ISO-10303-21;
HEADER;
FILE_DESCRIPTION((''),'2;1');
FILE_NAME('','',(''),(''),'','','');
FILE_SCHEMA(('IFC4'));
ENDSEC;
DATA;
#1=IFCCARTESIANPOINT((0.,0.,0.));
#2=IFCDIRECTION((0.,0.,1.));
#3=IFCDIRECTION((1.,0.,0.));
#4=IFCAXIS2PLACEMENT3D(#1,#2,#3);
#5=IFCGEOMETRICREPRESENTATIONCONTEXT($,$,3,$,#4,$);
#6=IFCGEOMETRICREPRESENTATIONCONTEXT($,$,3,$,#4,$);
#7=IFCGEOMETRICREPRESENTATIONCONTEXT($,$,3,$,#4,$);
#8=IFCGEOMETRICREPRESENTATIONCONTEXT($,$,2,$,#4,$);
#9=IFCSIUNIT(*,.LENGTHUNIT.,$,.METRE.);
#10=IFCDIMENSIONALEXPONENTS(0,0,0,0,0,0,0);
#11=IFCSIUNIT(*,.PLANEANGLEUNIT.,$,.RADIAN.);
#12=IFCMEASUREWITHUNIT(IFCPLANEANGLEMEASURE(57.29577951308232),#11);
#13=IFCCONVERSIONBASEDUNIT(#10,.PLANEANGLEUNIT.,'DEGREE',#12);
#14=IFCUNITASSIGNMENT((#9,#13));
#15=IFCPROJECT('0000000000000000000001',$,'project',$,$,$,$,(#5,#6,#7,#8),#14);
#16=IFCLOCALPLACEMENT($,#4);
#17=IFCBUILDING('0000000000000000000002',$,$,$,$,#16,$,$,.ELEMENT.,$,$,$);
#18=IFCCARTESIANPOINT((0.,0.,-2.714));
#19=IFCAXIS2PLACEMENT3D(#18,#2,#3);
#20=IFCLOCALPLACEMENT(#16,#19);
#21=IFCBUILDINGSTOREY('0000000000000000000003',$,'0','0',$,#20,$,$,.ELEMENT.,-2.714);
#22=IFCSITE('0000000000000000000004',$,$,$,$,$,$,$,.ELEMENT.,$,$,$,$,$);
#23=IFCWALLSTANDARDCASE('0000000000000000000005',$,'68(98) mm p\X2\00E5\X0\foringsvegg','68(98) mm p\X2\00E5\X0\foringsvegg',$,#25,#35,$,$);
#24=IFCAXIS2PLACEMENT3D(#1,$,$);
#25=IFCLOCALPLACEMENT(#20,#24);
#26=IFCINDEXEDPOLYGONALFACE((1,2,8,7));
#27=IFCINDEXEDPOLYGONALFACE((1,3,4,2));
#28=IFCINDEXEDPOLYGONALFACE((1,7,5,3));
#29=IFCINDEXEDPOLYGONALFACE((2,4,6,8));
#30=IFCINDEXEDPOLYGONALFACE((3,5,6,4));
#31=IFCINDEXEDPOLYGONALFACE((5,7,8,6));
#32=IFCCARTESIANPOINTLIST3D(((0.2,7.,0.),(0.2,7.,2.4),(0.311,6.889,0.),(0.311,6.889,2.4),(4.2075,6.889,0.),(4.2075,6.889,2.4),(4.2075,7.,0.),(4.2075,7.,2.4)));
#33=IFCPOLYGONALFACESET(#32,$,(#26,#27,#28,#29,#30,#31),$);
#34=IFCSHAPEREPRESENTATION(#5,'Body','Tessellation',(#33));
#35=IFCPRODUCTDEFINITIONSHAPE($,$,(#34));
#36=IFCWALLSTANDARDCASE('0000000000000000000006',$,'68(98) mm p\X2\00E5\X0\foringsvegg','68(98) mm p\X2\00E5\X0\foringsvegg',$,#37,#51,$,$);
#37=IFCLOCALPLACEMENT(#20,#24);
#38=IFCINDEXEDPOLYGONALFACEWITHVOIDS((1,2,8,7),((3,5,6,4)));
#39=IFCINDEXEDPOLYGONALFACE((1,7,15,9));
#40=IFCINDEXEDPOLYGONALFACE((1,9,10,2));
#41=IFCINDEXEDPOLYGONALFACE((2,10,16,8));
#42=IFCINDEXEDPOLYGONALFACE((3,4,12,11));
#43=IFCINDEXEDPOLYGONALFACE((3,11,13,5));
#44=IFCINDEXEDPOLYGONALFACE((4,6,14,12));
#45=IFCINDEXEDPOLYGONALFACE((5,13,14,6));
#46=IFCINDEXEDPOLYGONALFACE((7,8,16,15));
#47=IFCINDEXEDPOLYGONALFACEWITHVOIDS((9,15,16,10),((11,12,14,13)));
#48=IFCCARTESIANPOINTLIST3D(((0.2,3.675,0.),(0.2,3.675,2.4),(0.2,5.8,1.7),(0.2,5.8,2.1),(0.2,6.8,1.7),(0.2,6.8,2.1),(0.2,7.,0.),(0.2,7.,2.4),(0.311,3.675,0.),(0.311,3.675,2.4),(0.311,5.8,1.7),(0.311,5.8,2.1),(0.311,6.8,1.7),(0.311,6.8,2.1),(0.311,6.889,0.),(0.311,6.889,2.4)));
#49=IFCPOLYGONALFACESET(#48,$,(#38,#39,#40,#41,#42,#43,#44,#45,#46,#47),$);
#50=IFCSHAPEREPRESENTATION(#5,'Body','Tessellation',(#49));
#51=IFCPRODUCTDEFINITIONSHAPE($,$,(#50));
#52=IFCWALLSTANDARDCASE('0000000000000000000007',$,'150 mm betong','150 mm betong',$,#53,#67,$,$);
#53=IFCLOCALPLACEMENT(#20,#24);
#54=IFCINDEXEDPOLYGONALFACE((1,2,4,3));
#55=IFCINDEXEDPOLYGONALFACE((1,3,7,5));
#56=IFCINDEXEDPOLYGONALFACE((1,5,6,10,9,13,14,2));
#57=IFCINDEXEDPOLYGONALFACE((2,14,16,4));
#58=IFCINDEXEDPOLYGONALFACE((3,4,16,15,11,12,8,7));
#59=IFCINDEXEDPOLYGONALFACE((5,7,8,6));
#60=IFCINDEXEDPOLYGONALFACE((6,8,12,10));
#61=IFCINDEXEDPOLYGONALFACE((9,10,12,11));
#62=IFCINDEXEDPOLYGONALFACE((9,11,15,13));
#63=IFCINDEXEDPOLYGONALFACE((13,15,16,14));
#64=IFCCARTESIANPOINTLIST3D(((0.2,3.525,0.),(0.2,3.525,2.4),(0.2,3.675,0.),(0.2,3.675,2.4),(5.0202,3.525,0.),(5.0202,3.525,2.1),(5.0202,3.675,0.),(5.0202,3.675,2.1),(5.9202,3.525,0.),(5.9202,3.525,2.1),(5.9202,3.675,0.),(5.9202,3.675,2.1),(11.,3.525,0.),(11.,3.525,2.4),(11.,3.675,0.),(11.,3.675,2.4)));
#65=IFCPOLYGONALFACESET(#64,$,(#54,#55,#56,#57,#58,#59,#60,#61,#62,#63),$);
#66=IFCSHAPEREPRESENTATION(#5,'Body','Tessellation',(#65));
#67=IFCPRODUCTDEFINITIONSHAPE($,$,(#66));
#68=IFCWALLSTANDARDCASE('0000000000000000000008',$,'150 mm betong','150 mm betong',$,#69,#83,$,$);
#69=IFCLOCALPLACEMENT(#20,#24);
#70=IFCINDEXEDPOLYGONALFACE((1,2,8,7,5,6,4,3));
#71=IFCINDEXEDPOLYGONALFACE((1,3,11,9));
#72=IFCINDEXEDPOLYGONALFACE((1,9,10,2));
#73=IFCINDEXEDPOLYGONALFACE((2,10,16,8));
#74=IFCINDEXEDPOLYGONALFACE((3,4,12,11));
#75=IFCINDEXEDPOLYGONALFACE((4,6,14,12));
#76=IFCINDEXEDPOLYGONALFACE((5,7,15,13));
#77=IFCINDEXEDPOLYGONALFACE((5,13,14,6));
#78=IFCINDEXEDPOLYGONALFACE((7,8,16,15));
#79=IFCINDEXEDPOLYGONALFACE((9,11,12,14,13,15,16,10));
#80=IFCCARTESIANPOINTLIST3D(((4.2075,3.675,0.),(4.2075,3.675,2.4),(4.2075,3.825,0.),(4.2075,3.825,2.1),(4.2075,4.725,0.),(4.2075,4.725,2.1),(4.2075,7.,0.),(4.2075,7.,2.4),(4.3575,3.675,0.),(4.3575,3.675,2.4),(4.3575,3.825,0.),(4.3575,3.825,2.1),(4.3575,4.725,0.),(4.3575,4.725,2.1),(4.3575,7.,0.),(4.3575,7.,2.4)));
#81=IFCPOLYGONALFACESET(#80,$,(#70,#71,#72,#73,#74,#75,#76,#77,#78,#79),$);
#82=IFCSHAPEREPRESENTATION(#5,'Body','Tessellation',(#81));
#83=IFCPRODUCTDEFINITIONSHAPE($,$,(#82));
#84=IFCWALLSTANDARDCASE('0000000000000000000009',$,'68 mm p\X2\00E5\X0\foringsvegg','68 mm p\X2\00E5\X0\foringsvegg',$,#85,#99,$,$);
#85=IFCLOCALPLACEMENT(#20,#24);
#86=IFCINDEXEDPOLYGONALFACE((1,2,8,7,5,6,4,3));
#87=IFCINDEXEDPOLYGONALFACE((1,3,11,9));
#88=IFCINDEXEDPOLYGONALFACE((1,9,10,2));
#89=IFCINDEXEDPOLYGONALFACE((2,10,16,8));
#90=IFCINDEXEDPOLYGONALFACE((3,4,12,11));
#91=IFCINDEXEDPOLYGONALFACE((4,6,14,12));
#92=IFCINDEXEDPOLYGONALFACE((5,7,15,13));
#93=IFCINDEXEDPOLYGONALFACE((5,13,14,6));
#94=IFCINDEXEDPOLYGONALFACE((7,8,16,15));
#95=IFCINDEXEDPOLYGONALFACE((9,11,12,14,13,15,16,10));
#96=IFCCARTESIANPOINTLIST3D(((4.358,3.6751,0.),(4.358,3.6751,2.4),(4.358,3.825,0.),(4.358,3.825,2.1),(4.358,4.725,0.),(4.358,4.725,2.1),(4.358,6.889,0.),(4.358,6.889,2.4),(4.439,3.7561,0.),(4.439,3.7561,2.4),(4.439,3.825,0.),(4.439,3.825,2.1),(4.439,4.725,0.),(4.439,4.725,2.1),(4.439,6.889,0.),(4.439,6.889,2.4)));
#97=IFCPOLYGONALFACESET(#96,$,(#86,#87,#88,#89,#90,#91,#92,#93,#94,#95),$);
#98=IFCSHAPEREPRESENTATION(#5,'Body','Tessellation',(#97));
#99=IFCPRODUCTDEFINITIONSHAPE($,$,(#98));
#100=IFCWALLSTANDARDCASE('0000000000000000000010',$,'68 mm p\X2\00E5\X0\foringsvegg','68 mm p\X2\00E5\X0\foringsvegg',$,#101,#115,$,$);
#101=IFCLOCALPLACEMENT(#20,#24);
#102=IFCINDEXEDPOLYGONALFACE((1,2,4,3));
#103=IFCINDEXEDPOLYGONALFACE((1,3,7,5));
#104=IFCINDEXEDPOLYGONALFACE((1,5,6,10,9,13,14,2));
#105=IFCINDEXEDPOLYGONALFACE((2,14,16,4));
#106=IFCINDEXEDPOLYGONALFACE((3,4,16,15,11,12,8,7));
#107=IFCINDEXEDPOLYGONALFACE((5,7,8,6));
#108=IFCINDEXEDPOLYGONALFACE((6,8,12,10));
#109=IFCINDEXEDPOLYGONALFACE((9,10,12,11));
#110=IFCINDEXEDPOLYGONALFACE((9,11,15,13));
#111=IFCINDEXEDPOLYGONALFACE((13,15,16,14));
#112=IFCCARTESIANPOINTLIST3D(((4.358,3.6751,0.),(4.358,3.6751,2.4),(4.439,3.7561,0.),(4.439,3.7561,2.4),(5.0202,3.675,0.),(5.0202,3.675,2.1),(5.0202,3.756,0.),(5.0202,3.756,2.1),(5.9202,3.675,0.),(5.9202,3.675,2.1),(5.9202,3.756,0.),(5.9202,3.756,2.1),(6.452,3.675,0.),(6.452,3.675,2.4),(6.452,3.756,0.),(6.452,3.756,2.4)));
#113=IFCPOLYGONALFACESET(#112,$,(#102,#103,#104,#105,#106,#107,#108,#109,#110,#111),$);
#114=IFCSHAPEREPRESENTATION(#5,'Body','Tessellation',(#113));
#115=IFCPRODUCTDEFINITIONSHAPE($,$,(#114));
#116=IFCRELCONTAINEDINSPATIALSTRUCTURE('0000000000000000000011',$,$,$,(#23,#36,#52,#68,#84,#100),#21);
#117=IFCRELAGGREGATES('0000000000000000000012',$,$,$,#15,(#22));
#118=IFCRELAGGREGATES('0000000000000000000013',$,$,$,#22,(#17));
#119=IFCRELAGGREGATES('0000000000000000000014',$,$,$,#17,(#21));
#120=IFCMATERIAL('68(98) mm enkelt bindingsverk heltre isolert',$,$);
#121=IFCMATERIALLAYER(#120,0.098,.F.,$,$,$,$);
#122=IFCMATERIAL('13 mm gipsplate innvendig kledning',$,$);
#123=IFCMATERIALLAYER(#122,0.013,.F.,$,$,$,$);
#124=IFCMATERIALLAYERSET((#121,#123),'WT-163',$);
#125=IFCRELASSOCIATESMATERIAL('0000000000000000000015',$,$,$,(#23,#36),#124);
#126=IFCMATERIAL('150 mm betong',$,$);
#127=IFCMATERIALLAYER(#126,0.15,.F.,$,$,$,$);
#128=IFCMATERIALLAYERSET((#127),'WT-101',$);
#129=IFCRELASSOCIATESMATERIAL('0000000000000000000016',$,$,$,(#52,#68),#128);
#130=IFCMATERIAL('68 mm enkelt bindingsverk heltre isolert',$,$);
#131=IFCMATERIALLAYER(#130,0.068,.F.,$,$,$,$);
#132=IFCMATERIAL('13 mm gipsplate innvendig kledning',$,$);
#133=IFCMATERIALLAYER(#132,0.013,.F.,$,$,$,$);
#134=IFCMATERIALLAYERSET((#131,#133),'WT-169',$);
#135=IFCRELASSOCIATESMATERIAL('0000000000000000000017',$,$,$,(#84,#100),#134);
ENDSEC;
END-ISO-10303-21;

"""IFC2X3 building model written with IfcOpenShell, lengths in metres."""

from ifc_helpers import new_model, entity, si_unit, converted_unit, frame, origin_with_axes, place, context, project, spatial, polyline, outline, extrude, material, layer, layer_set, layer_usage, element, save


model = new_model("IFC2X3")

# Units and contexts
context_of_model_1 = context(None, 3, world=origin_with_axes())
context_of_model_2 = context(None, 3, world=origin_with_axes())
context_of_model_3 = context(None, 3, world=origin_with_axes())
context_of_model_4 = context(None, 2, world=origin_with_axes())
ifc_project = project(units=[si_unit("LENGTHUNIT", "METRE"), converted_unit("PLANEANGLEUNIT", "DEGREE", entity("IfcPlaneAngleMeasure", 57.29577951308232), si_unit("PLANEANGLEUNIT", "RADIAN"), dimensions=[0, 0, 0, 0, 0, 0, 0])], contexts=[context_of_model_1, context_of_model_2, context_of_model_3, context_of_model_4])

# Site, building, storey
site = spatial("IfcSite", under=ifc_project, CompositionType="ELEMENT")
building_placement = place(None, origin_with_axes())
building = spatial("IfcBuilding", under=site, at=building_placement, CompositionType="ELEMENT")
storey_placement = place(building_placement, frame((0.0, 0.0, -2.714), z_axis=(0.0, 0.0, 1.0), x_axis=(1.0, 0.0, 0.0)))
storey = spatial("IfcBuildingStorey", under=building, at=storey_placement, Name="0", Description="0", CompositionType="ELEMENT", Elevation=-2.714)

# Shared definitions
ifc_material_1 = material(Name="68(98) mm enkelt bindingsverk heltre isolert")
ifc_layer_1 = layer(ifc_material_1, 0.098, ventilated=False)
ifc_material_2 = material(Name="13 mm gipsplate innvendig kledning")
ifc_layer_2 = layer(ifc_material_2, 0.013, ventilated=False)
ifc_layer_set_1 = layer_set([ifc_layer_1, ifc_layer_2], Name="WT-163")
ifc_layer_usage_1 = layer_usage(ifc_layer_set_1, "AXIS2", "POSITIVE", 0.0)

# Wall
wall_1_placement = place(storey_placement, frame((4.2075, 7.0, 0.0), z_axis=(0.0, 0.0, 1.0), x_axis=(-1.0, 0.0, 0.0)))
element("IfcWallStandardCase", 1, at=wall_1_placement, inside=storey, material=ifc_layer_usage_1, Name="68(98) mm påforingsvegg", Description="68(98) mm påforingsvegg", context=context_of_model_1, shape_type="SweptSolid", body=[
    extrude(outline(polyline([(0.0, 0.0), (4.0075, 0.0), (3.8965, 0.111), (0.0, 0.111), (0.0, 0.0)])), frame((0.0, 0.0, 0.0), z_axis=(0.0, 0.0, 1.0), x_axis=(1.0, 0.0, 0.0)), (0.0, 0.0, 1.0), 2.4),
])

# Walls, openings
wall_2_placement = place(storey_placement, frame((0.2, 7.0, 0.0), z_axis=(0.0, 0.0, 1.0), x_axis=(0.0, -1.0, 0.0)))
wall_2 = element("IfcWallStandardCase", 2, at=wall_2_placement, inside=storey, material=ifc_layer_usage_1, Name="68(98) mm påforingsvegg", Description="68(98) mm påforingsvegg", context=context_of_model_1, shape_type="SweptSolid", body=[
    extrude(outline(polyline([(0.0, 0.0), (3.325, 0.0), (3.325, 0.111), (0.111, 0.111), (0.0, 0.0)])), frame((0.0, 0.0, 0.0), z_axis=(0.0, 0.0, 1.0), x_axis=(1.0, 0.0, 0.0)), (0.0, 0.0, 1.0), 2.4),
])
opening_1_placement = place(wall_2_placement, frame((0.2, 0.0, 1.7), z_axis=(0.0, 0.0, 1.0), x_axis=(1.0, 0.0, 0.0)))
element("IfcOpeningElement", 3, at=opening_1_placement, inside=storey, cuts=wall_2, context=context_of_model_1, shape_type="SweptSolid", body=[
    extrude(outline(polyline([(0.0, 0.0), (0.4, 0.0), (0.4, 1.0), (0.0, 1.0), (0.0, 0.0)])), frame((0.0, 0.0, 0.0), z_axis=(0.0, 1.0, 0.0), x_axis=(0.0, 0.0, 1.0)), (0.0, 0.0, 1.0), 0.111),
])
ifc_material_3 = material(Name="150 mm betong")
ifc_layer_3 = layer(ifc_material_3, 0.15, ventilated=False)
ifc_layer_set_2 = layer_set([ifc_layer_3], Name="WT-101")
ifc_layer_usage_2 = layer_usage(ifc_layer_set_2, "AXIS2", "POSITIVE", 0.0)
wall_3_placement = place(storey_placement, frame((0.2, 3.525, 0.0), z_axis=(0.0, 0.0, 1.0), x_axis=(1.0, 0.0, 0.0)))
wall_3 = element("IfcWallStandardCase", 4, at=wall_3_placement, inside=storey, material=ifc_layer_usage_2, Name="150 mm betong", Description="150 mm betong", context=context_of_model_1, shape_type="SweptSolid", body=[
    extrude(outline(polyline([(0.0, 0.0), (10.8, 0.0), (10.8, 0.15), (0.0, 0.15), (0.0, 0.0)])), origin_with_axes(), (0.0, 0.0, 1.0), 2.4),
])
opening_2_placement = place(wall_3_placement, frame((4.8202, 0.0, 0.0), z_axis=(0.0, 0.0, 1.0), x_axis=(1.0, 0.0, 0.0)))
element("IfcOpeningElement", 5, at=opening_2_placement, inside=storey, cuts=wall_3, context=context_of_model_1, shape_type="SweptSolid", body=[
    extrude(outline(polyline([(0.0, 0.0), (2.1, 0.0), (2.1, 0.9), (0.0, 0.9), (0.0, 0.0)])), frame((0.0, 0.0, 0.0), z_axis=(0.0, 1.0, 0.0), x_axis=(0.0, 0.0, 1.0)), (0.0, 0.0, 1.0), 0.15),
])
wall_4_placement = place(storey_placement, frame((4.2075, 7.0, 0.0), z_axis=(0.0, 0.0, 1.0), x_axis=(0.0, -1.0, 0.0)))
wall_4 = element("IfcWallStandardCase", 6, at=wall_4_placement, inside=storey, material=ifc_layer_usage_2, Name="150 mm betong", Description="150 mm betong", context=context_of_model_1, shape_type="SweptSolid", body=[
    extrude(outline(polyline([(0.0, 0.0), (3.325, 0.0), (3.325, 0.15), (0.0, 0.15), (0.0, 0.0)])), frame((0.0, 0.0, 0.0), z_axis=(0.0, 0.0, 1.0), x_axis=(1.0, 0.0, 0.0)), (0.0, 0.0, 1.0), 2.4),
])
opening_3_placement = place(wall_4_placement, frame((2.275, 0.0, 0.0), z_axis=(0.0, 0.0, 1.0), x_axis=(1.0, 0.0, 0.0)))
element("IfcOpeningElement", 7, at=opening_3_placement, inside=storey, cuts=wall_4, context=context_of_model_1, shape_type="SweptSolid", body=[
    extrude(outline(polyline([(0.0, 0.0), (2.1, 0.0), (2.1, 0.9), (0.0, 0.9), (0.0, 0.0)])), frame((0.0, 0.0, 0.0), z_axis=(0.0, 1.0, 0.0), x_axis=(0.0, 0.0, 1.0)), (0.0, 0.0, 1.0), 0.15),
])
ifc_material_4 = material(Name="68 mm enkelt bindingsverk heltre isolert")
ifc_layer_4 = layer(ifc_material_4, 0.068, ventilated=False)
ifc_material_5 = material(Name="13 mm gipsplate innvendig kledning")
ifc_layer_5 = layer(ifc_material_5, 0.013, ventilated=False)
ifc_layer_set_3 = layer_set([ifc_layer_4, ifc_layer_5], Name="WT-169")
ifc_layer_usage_3 = layer_usage(ifc_layer_set_3, "AXIS2", "POSITIVE", 0.0)
wall_5_placement = place(storey_placement, frame((4.358, 6.889, 0.0), z_axis=(0.0, 0.0, 1.0), x_axis=(0.0, -1.0, 0.0)))
wall_5 = element("IfcWallStandardCase", 8, at=wall_5_placement, inside=storey, material=ifc_layer_usage_3, Name="68 mm påforingsvegg", Description="68 mm påforingsvegg", context=context_of_model_1, shape_type="SweptSolid", body=[
    extrude(outline(polyline([(0.0, 0.0), (3.2139, 0.0), (3.1329, 0.081), (0.0, 0.081), (0.0, 0.0)])), frame((0.0, 0.0, 0.0), z_axis=(0.0, 0.0, 1.0), x_axis=(1.0, 0.0, 0.0)), (0.0, 0.0, 1.0), 2.4),
])
opening_4_placement = place(wall_5_placement, frame((2.164, 0.0, 0.0), z_axis=(0.0, 0.0, 1.0), x_axis=(1.0, 0.0, 0.0)))
element("IfcOpeningElement", 9, at=opening_4_placement, inside=storey, cuts=wall_5, context=context_of_model_1, shape_type="SweptSolid", body=[
    extrude(outline(polyline([(0.0, 0.0), (2.1, 0.0), (2.1, 0.9), (0.0, 0.9), (0.0, 0.0)])), frame((0.0, 0.0, 0.0), z_axis=(0.0, 1.0, 0.0), x_axis=(0.0, 0.0, 1.0)), (0.0, 0.0, 1.0), 0.081),
])
wall_6_placement = place(storey_placement, frame((4.358, 3.6751, 0.0), z_axis=(0.0, 0.0, 1.0), x_axis=(1.0, 0.0, 0.0)))
wall_6 = element("IfcWallStandardCase", 10, at=wall_6_placement, inside=storey, material=ifc_layer_usage_3, Name="68 mm påforingsvegg", Description="68 mm påforingsvegg", context=context_of_model_1, shape_type="SweptSolid", body=[
    extrude(outline(polyline([(0.0, 0.0), (2.094, 0.0), (2.094, 0.081), (0.081, 0.081), (0.0, 0.0)])), frame((0.0, 0.0, 0.0), z_axis=(0.0, 0.0, 1.0), x_axis=(1.0, -0.000001, 0.0)), (0.0, 0.0, 1.0), 2.4),
])
opening_5_placement = place(wall_6_placement, frame((0.6622, 0.0, 0.0), z_axis=(0.0, 0.0, 1.0), x_axis=(1.0, 0.0, 0.0)))
element("IfcOpeningElement", 11, at=opening_5_placement, inside=storey, cuts=wall_6, context=context_of_model_1, shape_type="SweptSolid", body=[
    extrude(outline(polyline([(0.0, 0.0), (2.1, 0.0), (2.1, 0.9), (0.0, 0.9), (0.0, 0.0)])), frame((0.0, 0.0, 0.0), z_axis=(0.000001, 1.0, 0.0), x_axis=(0.0, 0.0, 1.0)), (0.0, -0.000001, 1.0), 0.081),
])

save(model, "model.ifc")
